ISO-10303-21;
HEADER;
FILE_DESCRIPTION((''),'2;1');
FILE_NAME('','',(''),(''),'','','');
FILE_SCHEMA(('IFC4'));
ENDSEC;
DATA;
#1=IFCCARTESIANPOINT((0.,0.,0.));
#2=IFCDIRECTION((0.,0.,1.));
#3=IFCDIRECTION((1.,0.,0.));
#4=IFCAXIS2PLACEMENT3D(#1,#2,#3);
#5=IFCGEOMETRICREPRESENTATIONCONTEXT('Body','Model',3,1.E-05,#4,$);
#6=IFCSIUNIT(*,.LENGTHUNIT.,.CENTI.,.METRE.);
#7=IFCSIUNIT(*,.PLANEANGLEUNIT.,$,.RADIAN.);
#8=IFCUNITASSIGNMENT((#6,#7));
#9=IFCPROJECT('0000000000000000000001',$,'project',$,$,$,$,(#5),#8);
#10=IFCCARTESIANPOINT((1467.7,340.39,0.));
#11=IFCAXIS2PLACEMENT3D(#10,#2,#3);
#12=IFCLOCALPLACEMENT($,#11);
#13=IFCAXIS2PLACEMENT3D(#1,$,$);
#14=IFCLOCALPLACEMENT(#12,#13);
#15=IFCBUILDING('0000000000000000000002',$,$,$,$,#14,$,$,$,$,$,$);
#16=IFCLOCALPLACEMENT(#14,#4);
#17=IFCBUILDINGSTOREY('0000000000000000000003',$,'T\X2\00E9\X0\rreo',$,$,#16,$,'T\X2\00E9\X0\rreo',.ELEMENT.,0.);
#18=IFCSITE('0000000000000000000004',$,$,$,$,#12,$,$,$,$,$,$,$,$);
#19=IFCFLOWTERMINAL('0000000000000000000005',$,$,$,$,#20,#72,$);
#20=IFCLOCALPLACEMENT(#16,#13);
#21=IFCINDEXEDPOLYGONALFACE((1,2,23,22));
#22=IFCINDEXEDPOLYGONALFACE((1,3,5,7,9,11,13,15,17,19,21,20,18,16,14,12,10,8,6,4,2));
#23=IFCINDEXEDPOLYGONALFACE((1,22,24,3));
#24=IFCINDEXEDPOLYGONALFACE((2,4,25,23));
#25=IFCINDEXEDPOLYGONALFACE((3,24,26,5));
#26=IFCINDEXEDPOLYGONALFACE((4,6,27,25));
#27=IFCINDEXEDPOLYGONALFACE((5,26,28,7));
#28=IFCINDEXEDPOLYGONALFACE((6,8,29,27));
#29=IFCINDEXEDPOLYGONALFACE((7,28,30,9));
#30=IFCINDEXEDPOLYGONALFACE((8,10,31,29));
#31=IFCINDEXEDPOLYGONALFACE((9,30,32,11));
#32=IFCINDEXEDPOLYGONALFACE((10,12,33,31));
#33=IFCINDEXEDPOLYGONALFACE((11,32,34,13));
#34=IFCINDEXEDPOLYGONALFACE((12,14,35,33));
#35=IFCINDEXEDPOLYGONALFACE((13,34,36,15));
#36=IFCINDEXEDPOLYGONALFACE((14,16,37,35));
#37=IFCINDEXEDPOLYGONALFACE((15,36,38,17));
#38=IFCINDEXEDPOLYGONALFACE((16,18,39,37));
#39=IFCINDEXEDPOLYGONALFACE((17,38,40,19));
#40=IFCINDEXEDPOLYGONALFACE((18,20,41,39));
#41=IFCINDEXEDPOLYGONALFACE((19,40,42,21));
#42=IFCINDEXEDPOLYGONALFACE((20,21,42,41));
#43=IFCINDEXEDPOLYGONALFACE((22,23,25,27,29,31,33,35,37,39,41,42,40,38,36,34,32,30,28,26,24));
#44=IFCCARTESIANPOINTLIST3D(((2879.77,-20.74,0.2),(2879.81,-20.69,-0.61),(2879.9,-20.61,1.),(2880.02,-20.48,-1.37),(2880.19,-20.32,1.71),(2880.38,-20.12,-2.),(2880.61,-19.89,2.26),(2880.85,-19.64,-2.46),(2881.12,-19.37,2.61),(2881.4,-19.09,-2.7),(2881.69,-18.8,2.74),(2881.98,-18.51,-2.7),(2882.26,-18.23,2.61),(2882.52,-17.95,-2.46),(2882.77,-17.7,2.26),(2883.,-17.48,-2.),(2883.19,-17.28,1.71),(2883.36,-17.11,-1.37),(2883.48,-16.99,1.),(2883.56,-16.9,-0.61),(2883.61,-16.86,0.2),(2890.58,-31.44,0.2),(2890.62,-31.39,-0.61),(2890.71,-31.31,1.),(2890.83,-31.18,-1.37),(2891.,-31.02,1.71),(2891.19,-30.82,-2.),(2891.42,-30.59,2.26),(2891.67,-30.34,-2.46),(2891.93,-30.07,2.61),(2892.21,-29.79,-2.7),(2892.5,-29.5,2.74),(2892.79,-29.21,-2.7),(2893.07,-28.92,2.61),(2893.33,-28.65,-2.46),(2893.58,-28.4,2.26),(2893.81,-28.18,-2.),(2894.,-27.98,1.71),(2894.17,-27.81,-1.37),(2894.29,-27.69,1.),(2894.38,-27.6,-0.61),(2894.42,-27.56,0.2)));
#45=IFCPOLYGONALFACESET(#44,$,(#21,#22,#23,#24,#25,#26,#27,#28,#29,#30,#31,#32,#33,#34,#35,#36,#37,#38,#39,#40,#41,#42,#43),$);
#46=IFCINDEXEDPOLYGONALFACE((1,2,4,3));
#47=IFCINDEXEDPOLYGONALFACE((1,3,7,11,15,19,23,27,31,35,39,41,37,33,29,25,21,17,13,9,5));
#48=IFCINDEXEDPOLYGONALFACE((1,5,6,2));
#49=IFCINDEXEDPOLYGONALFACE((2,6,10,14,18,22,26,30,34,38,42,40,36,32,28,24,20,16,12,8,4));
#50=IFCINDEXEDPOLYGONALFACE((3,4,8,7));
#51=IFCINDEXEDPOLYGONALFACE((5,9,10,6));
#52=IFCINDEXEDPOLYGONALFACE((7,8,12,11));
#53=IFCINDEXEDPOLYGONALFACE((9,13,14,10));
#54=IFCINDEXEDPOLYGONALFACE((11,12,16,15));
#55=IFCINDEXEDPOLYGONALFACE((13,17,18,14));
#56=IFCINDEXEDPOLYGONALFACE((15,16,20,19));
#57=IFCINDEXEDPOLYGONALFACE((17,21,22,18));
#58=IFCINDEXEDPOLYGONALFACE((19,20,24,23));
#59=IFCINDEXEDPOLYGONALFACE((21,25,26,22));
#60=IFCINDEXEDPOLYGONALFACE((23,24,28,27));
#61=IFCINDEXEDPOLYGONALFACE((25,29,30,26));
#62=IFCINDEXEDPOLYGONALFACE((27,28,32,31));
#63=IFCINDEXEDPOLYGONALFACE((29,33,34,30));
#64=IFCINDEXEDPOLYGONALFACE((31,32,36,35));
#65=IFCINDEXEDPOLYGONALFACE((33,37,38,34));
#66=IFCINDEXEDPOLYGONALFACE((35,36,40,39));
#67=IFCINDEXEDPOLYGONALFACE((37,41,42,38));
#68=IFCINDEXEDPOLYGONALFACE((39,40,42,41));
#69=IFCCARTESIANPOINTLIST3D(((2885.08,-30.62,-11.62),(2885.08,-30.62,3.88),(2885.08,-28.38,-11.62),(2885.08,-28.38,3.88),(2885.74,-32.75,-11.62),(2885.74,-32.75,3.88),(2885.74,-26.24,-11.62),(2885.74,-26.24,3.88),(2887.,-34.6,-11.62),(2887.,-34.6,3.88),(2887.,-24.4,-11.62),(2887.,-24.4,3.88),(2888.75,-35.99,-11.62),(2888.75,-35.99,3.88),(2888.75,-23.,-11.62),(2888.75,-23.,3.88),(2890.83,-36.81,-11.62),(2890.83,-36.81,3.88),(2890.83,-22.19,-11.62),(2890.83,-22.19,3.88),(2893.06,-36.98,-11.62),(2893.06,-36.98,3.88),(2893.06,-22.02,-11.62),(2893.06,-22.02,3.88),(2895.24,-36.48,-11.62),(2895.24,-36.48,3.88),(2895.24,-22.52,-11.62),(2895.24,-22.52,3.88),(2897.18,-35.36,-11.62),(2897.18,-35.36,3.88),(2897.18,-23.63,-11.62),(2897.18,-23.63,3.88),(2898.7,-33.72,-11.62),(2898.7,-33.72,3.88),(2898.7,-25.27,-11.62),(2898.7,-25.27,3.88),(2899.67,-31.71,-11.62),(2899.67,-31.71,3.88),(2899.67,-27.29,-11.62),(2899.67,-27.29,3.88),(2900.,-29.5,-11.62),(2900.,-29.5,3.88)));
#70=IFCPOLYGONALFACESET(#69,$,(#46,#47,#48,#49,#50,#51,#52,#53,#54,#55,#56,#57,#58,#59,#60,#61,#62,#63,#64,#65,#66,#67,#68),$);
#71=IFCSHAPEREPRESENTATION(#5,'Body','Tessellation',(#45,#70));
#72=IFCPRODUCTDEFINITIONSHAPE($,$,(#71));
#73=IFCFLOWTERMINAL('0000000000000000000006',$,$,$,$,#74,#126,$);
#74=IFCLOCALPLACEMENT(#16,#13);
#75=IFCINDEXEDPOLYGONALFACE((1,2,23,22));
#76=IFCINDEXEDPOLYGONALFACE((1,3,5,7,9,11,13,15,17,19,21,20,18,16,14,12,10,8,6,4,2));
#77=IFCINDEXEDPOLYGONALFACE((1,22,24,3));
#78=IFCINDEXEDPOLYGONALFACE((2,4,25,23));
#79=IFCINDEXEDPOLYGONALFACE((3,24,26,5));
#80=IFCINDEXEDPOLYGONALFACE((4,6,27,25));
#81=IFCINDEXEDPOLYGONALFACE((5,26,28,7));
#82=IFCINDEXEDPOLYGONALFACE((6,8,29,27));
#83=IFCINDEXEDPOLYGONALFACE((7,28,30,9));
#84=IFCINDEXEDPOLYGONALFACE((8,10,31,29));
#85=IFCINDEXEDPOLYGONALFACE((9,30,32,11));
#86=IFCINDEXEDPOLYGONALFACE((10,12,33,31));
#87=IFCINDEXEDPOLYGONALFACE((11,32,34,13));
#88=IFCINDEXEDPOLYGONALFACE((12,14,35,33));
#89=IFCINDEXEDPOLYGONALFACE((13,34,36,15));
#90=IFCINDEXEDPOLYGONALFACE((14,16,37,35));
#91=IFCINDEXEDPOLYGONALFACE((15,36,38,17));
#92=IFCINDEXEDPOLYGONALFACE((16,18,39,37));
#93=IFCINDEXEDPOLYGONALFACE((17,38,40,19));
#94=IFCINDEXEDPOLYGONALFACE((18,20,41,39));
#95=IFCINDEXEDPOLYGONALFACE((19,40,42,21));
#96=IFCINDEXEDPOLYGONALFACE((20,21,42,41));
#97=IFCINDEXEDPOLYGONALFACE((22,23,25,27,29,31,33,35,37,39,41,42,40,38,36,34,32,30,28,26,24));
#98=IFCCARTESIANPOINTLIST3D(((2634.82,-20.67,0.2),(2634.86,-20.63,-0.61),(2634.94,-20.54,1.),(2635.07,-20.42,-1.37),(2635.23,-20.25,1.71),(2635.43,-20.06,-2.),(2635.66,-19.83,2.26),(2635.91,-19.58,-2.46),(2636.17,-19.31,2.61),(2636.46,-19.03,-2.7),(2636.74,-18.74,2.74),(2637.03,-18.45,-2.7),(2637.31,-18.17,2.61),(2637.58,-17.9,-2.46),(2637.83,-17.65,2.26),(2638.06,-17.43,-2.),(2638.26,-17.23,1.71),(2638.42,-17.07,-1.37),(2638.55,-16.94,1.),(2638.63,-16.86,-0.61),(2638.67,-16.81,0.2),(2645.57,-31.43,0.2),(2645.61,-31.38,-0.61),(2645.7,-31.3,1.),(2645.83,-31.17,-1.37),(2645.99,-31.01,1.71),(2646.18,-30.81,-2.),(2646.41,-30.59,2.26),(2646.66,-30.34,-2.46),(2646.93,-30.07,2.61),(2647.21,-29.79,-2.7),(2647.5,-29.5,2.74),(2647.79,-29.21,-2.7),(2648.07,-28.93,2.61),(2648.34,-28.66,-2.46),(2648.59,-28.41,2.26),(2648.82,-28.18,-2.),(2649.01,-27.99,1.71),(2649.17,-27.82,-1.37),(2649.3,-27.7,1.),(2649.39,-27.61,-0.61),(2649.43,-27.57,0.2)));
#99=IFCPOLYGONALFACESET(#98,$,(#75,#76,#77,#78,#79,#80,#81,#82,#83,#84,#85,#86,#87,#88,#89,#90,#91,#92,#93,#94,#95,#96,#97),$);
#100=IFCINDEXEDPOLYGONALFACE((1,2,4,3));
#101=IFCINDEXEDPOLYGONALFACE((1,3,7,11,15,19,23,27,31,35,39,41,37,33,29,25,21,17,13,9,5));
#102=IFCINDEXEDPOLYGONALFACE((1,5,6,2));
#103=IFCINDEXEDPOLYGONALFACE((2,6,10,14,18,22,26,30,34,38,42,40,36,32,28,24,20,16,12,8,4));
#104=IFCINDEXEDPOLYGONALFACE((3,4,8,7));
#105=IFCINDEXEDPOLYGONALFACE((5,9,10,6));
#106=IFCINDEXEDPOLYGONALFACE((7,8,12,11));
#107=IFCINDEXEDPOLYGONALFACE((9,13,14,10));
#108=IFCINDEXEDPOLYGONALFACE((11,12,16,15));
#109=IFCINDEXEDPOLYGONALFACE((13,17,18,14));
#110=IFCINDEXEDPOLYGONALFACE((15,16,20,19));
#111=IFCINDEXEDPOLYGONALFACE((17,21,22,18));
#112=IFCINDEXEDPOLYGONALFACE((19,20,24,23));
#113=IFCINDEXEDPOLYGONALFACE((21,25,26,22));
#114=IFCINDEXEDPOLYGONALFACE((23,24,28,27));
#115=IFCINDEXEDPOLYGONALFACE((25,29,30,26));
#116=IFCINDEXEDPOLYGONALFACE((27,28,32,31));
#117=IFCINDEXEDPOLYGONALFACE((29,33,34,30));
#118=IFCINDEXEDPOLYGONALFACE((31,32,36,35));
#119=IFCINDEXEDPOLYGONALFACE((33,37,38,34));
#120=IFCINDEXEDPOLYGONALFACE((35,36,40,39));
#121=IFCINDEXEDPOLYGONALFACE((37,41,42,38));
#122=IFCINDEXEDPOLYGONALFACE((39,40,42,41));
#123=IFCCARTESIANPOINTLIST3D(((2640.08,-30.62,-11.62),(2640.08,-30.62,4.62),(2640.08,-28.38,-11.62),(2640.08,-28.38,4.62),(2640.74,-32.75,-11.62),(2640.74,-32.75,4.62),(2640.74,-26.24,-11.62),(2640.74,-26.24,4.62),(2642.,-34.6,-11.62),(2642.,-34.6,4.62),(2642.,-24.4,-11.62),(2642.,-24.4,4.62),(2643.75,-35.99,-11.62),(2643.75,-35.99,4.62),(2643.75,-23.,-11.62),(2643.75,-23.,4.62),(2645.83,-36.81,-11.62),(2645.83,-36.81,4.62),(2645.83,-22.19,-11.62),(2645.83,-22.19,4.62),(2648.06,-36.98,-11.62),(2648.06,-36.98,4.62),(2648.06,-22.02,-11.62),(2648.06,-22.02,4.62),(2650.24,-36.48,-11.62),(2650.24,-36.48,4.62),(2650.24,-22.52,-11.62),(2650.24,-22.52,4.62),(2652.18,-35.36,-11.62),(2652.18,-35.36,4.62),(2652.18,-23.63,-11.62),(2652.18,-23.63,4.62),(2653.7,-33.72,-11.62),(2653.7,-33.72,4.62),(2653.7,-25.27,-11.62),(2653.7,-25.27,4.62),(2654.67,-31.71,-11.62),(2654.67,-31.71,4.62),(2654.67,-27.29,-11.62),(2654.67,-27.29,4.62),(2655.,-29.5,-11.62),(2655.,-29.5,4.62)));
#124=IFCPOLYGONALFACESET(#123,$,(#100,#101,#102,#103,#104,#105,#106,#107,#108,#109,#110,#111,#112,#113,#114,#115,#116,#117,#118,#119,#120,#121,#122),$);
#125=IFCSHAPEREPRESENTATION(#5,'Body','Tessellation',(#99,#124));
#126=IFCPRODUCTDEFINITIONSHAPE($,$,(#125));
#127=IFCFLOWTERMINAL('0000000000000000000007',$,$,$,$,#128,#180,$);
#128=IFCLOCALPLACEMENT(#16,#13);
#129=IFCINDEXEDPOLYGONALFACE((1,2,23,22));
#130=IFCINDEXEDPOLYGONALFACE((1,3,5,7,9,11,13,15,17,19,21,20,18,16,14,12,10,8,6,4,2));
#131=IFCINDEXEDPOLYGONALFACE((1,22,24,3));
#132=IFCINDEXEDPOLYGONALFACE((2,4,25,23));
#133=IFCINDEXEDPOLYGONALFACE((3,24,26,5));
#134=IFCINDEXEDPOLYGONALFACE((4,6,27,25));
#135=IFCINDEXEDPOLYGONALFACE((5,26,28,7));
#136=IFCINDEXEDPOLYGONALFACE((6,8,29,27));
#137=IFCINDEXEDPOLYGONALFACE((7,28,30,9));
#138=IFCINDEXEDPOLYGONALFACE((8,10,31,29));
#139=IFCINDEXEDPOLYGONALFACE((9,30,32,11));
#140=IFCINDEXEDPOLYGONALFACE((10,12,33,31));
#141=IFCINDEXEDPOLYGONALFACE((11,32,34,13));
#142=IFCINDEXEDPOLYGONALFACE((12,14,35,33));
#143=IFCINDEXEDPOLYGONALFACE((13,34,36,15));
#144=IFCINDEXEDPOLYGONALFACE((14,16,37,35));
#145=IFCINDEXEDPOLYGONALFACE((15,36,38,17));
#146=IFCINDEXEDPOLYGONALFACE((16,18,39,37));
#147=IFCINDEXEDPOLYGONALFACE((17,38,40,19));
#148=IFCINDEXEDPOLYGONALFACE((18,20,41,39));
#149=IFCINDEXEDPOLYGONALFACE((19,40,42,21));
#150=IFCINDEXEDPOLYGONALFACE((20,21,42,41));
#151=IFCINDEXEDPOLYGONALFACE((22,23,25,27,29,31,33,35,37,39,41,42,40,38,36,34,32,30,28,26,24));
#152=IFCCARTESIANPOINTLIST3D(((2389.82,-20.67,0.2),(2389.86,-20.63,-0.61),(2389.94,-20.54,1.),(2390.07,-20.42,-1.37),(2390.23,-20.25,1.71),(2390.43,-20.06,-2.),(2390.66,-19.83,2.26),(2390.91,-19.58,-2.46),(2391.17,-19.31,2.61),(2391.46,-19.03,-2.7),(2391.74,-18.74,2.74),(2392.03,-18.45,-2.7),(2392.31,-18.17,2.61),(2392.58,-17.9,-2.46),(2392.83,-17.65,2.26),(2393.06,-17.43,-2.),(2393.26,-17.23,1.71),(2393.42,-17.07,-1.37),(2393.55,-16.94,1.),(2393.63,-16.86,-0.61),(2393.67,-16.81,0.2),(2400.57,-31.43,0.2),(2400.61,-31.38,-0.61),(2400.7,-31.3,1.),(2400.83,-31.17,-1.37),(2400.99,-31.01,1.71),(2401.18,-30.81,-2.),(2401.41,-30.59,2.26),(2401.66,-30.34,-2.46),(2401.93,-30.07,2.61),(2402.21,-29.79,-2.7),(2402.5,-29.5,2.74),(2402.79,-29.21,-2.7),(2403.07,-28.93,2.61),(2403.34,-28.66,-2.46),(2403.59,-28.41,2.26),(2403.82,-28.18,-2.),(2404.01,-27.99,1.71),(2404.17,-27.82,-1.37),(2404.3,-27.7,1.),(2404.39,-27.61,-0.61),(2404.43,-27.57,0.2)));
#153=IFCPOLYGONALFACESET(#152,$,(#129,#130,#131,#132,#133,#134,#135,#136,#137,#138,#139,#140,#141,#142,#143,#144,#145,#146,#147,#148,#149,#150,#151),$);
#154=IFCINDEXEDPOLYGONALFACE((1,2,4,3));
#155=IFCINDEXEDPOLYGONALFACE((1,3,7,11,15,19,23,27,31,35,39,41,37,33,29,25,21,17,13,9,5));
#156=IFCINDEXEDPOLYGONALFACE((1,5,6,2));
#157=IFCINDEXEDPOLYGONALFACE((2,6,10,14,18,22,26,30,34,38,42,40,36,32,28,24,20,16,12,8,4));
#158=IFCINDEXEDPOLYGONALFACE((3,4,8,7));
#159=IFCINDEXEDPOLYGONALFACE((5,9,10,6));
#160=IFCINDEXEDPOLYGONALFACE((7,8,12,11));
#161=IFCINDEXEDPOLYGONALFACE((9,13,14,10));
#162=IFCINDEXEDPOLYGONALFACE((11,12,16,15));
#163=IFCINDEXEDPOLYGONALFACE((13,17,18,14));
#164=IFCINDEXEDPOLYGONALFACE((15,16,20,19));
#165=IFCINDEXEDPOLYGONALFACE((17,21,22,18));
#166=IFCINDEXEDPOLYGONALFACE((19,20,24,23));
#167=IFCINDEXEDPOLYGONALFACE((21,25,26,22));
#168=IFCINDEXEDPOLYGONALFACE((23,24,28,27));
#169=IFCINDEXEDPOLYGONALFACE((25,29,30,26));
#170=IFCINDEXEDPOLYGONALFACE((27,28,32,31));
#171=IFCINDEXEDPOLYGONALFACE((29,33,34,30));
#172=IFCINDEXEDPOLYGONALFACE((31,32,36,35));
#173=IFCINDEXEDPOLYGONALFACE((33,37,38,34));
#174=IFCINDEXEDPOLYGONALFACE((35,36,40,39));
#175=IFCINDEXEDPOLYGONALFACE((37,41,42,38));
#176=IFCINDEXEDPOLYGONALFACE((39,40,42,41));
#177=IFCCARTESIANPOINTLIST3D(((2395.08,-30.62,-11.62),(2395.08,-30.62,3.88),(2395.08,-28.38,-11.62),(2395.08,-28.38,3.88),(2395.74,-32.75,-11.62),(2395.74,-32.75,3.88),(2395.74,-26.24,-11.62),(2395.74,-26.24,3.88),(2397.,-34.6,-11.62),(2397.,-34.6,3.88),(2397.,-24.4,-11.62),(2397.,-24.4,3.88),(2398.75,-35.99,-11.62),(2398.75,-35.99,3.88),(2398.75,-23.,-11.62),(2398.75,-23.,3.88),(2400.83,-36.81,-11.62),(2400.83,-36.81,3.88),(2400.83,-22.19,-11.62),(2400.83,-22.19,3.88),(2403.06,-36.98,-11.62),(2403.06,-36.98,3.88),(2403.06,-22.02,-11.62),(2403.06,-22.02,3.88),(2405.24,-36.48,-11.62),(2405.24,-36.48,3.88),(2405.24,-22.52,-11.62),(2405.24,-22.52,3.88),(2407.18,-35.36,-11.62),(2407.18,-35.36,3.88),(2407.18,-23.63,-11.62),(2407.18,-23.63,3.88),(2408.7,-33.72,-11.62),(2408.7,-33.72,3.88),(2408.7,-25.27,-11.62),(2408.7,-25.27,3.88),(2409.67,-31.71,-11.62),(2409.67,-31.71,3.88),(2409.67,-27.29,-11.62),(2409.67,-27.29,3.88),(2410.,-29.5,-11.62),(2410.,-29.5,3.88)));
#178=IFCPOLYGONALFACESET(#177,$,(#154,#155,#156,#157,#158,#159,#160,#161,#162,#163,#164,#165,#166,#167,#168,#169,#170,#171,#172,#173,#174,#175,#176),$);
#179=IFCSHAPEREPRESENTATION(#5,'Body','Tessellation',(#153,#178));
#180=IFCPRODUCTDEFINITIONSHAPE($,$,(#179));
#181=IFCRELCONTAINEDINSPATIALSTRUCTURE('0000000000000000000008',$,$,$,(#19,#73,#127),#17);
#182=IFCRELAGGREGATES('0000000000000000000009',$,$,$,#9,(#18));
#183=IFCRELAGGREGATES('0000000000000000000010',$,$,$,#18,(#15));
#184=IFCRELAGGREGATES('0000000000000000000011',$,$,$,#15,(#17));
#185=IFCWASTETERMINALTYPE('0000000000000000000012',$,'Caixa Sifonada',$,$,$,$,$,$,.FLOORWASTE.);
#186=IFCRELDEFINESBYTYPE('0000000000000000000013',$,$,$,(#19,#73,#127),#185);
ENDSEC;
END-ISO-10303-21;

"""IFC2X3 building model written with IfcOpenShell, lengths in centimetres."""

from ifc_helpers import new_model, si_unit, frame, origin, origin_with_axes, origin_2d_with_axis, place, context, project, spatial, circle, extrude, type_object, element, save


model = new_model("IFC2X3")

# Units and contexts
model_context = context("Model", 3, precision=1e-05, world=origin_with_axes(), identifier="Body")
ifc_project = project(units=[si_unit("LENGTHUNIT", "METRE", prefix="CENTI"), si_unit("PLANEANGLEUNIT", "RADIAN")], contexts=[model_context])

# Site, building, storey
site_placement = place(None, frame((1467.7, 340.39, 0.0), z_axis=(0.0, 0.0, 1.0), x_axis=(1.0, 0.0, 0.0)))
site = spatial("IfcSite", under=ifc_project, at=site_placement)
building_placement = place(site_placement, origin())
building = spatial("IfcBuilding", under=site, at=building_placement)
storey_placement = place(building_placement, origin_with_axes())
storey = spatial("IfcBuildingStorey", under=building, at=storey_placement, Name="Térreo", LongName="Térreo", CompositionType="ELEMENT", Elevation=0.0)

# Flow terminals
waste_terminal_type_1 = type_object("IfcWasteTerminalType", Name="Caixa Sifonada", PredefinedType="FLOORWASTE")
flow_terminal_1_placement = place(storey_placement, frame((2889.88, -26.93, 3.88), z_axis=(0.0, 0.0, 1.0), x_axis=(1.0, 0.0, 0.0)))
element("IfcFlowTerminal", 1, at=flow_terminal_1_placement, inside=storey, type_object=waste_terminal_type_1, context=model_context, shape_type="SolidModel", body=[
    extrude(circle(Radius=2.73, at=origin_2d_with_axis()), frame((2.62, -2.57, -3.88), z_axis=(-0.71076, 0.703434, 0.0), x_axis=(0.0, 0.0, 1.0)), (0.0, 0.0, 1.0), 15.21),
    extrude(circle(Radius=7.5, at=origin_2d_with_axis()), frame((2.62, -2.57, -15.5), z_axis=(0.0, 0.0, 1.0), x_axis=(1.0, 0.0, 0.0)), (0.0, 0.0, 1.0), 15.5),
])
flow_terminal_2_placement = place(storey_placement, frame((2644.91, -26.9, 4.62), z_axis=(0.0, 0.0, 1.0), x_axis=(1.0, 0.0, 0.0)))
element("IfcFlowTerminal", 2, at=flow_terminal_2_placement, inside=storey, type_object=waste_terminal_type_1, context=model_context, shape_type="SolidModel", body=[
    extrude(circle(Radius=2.73, at=origin_2d_with_axis()), frame((2.59, -2.59, -4.62), z_axis=(-0.707107, 0.707107, 0.0), x_axis=(0.0, 0.0, 1.0)), (0.0, 0.0, 1.0), 15.21),
    extrude(circle(Radius=7.5, at=origin_2d_with_axis()), frame((2.59, -2.59, -16.25), z_axis=(0.0, 0.0, 1.0), x_axis=(1.0, 0.0, 0.0)), (0.0, 0.0, 1.0), 16.25),
])
flow_terminal_3_placement = place(storey_placement, frame((2399.91, -26.9, 3.88), z_axis=(0.0, 0.0, 1.0), x_axis=(1.0, 0.0, 0.0)))
element("IfcFlowTerminal", 3, at=flow_terminal_3_placement, inside=storey, type_object=waste_terminal_type_1, context=model_context, shape_type="SolidModel", body=[
    extrude(circle(Radius=2.73, at=origin_2d_with_axis()), frame((2.59, -2.59, -3.88), z_axis=(-0.707107, 0.707107, 0.0), x_axis=(0.0, 0.0, 1.0)), (0.0, 0.0, 1.0), 15.21),
    extrude(circle(Radius=7.5, at=origin_2d_with_axis()), frame((2.59, -2.59, -15.5), z_axis=(0.0, 0.0, 1.0), x_axis=(1.0, 0.0, 0.0)), (0.0, 0.0, 1.0), 15.5),
])

save(model, "model.ifc")
